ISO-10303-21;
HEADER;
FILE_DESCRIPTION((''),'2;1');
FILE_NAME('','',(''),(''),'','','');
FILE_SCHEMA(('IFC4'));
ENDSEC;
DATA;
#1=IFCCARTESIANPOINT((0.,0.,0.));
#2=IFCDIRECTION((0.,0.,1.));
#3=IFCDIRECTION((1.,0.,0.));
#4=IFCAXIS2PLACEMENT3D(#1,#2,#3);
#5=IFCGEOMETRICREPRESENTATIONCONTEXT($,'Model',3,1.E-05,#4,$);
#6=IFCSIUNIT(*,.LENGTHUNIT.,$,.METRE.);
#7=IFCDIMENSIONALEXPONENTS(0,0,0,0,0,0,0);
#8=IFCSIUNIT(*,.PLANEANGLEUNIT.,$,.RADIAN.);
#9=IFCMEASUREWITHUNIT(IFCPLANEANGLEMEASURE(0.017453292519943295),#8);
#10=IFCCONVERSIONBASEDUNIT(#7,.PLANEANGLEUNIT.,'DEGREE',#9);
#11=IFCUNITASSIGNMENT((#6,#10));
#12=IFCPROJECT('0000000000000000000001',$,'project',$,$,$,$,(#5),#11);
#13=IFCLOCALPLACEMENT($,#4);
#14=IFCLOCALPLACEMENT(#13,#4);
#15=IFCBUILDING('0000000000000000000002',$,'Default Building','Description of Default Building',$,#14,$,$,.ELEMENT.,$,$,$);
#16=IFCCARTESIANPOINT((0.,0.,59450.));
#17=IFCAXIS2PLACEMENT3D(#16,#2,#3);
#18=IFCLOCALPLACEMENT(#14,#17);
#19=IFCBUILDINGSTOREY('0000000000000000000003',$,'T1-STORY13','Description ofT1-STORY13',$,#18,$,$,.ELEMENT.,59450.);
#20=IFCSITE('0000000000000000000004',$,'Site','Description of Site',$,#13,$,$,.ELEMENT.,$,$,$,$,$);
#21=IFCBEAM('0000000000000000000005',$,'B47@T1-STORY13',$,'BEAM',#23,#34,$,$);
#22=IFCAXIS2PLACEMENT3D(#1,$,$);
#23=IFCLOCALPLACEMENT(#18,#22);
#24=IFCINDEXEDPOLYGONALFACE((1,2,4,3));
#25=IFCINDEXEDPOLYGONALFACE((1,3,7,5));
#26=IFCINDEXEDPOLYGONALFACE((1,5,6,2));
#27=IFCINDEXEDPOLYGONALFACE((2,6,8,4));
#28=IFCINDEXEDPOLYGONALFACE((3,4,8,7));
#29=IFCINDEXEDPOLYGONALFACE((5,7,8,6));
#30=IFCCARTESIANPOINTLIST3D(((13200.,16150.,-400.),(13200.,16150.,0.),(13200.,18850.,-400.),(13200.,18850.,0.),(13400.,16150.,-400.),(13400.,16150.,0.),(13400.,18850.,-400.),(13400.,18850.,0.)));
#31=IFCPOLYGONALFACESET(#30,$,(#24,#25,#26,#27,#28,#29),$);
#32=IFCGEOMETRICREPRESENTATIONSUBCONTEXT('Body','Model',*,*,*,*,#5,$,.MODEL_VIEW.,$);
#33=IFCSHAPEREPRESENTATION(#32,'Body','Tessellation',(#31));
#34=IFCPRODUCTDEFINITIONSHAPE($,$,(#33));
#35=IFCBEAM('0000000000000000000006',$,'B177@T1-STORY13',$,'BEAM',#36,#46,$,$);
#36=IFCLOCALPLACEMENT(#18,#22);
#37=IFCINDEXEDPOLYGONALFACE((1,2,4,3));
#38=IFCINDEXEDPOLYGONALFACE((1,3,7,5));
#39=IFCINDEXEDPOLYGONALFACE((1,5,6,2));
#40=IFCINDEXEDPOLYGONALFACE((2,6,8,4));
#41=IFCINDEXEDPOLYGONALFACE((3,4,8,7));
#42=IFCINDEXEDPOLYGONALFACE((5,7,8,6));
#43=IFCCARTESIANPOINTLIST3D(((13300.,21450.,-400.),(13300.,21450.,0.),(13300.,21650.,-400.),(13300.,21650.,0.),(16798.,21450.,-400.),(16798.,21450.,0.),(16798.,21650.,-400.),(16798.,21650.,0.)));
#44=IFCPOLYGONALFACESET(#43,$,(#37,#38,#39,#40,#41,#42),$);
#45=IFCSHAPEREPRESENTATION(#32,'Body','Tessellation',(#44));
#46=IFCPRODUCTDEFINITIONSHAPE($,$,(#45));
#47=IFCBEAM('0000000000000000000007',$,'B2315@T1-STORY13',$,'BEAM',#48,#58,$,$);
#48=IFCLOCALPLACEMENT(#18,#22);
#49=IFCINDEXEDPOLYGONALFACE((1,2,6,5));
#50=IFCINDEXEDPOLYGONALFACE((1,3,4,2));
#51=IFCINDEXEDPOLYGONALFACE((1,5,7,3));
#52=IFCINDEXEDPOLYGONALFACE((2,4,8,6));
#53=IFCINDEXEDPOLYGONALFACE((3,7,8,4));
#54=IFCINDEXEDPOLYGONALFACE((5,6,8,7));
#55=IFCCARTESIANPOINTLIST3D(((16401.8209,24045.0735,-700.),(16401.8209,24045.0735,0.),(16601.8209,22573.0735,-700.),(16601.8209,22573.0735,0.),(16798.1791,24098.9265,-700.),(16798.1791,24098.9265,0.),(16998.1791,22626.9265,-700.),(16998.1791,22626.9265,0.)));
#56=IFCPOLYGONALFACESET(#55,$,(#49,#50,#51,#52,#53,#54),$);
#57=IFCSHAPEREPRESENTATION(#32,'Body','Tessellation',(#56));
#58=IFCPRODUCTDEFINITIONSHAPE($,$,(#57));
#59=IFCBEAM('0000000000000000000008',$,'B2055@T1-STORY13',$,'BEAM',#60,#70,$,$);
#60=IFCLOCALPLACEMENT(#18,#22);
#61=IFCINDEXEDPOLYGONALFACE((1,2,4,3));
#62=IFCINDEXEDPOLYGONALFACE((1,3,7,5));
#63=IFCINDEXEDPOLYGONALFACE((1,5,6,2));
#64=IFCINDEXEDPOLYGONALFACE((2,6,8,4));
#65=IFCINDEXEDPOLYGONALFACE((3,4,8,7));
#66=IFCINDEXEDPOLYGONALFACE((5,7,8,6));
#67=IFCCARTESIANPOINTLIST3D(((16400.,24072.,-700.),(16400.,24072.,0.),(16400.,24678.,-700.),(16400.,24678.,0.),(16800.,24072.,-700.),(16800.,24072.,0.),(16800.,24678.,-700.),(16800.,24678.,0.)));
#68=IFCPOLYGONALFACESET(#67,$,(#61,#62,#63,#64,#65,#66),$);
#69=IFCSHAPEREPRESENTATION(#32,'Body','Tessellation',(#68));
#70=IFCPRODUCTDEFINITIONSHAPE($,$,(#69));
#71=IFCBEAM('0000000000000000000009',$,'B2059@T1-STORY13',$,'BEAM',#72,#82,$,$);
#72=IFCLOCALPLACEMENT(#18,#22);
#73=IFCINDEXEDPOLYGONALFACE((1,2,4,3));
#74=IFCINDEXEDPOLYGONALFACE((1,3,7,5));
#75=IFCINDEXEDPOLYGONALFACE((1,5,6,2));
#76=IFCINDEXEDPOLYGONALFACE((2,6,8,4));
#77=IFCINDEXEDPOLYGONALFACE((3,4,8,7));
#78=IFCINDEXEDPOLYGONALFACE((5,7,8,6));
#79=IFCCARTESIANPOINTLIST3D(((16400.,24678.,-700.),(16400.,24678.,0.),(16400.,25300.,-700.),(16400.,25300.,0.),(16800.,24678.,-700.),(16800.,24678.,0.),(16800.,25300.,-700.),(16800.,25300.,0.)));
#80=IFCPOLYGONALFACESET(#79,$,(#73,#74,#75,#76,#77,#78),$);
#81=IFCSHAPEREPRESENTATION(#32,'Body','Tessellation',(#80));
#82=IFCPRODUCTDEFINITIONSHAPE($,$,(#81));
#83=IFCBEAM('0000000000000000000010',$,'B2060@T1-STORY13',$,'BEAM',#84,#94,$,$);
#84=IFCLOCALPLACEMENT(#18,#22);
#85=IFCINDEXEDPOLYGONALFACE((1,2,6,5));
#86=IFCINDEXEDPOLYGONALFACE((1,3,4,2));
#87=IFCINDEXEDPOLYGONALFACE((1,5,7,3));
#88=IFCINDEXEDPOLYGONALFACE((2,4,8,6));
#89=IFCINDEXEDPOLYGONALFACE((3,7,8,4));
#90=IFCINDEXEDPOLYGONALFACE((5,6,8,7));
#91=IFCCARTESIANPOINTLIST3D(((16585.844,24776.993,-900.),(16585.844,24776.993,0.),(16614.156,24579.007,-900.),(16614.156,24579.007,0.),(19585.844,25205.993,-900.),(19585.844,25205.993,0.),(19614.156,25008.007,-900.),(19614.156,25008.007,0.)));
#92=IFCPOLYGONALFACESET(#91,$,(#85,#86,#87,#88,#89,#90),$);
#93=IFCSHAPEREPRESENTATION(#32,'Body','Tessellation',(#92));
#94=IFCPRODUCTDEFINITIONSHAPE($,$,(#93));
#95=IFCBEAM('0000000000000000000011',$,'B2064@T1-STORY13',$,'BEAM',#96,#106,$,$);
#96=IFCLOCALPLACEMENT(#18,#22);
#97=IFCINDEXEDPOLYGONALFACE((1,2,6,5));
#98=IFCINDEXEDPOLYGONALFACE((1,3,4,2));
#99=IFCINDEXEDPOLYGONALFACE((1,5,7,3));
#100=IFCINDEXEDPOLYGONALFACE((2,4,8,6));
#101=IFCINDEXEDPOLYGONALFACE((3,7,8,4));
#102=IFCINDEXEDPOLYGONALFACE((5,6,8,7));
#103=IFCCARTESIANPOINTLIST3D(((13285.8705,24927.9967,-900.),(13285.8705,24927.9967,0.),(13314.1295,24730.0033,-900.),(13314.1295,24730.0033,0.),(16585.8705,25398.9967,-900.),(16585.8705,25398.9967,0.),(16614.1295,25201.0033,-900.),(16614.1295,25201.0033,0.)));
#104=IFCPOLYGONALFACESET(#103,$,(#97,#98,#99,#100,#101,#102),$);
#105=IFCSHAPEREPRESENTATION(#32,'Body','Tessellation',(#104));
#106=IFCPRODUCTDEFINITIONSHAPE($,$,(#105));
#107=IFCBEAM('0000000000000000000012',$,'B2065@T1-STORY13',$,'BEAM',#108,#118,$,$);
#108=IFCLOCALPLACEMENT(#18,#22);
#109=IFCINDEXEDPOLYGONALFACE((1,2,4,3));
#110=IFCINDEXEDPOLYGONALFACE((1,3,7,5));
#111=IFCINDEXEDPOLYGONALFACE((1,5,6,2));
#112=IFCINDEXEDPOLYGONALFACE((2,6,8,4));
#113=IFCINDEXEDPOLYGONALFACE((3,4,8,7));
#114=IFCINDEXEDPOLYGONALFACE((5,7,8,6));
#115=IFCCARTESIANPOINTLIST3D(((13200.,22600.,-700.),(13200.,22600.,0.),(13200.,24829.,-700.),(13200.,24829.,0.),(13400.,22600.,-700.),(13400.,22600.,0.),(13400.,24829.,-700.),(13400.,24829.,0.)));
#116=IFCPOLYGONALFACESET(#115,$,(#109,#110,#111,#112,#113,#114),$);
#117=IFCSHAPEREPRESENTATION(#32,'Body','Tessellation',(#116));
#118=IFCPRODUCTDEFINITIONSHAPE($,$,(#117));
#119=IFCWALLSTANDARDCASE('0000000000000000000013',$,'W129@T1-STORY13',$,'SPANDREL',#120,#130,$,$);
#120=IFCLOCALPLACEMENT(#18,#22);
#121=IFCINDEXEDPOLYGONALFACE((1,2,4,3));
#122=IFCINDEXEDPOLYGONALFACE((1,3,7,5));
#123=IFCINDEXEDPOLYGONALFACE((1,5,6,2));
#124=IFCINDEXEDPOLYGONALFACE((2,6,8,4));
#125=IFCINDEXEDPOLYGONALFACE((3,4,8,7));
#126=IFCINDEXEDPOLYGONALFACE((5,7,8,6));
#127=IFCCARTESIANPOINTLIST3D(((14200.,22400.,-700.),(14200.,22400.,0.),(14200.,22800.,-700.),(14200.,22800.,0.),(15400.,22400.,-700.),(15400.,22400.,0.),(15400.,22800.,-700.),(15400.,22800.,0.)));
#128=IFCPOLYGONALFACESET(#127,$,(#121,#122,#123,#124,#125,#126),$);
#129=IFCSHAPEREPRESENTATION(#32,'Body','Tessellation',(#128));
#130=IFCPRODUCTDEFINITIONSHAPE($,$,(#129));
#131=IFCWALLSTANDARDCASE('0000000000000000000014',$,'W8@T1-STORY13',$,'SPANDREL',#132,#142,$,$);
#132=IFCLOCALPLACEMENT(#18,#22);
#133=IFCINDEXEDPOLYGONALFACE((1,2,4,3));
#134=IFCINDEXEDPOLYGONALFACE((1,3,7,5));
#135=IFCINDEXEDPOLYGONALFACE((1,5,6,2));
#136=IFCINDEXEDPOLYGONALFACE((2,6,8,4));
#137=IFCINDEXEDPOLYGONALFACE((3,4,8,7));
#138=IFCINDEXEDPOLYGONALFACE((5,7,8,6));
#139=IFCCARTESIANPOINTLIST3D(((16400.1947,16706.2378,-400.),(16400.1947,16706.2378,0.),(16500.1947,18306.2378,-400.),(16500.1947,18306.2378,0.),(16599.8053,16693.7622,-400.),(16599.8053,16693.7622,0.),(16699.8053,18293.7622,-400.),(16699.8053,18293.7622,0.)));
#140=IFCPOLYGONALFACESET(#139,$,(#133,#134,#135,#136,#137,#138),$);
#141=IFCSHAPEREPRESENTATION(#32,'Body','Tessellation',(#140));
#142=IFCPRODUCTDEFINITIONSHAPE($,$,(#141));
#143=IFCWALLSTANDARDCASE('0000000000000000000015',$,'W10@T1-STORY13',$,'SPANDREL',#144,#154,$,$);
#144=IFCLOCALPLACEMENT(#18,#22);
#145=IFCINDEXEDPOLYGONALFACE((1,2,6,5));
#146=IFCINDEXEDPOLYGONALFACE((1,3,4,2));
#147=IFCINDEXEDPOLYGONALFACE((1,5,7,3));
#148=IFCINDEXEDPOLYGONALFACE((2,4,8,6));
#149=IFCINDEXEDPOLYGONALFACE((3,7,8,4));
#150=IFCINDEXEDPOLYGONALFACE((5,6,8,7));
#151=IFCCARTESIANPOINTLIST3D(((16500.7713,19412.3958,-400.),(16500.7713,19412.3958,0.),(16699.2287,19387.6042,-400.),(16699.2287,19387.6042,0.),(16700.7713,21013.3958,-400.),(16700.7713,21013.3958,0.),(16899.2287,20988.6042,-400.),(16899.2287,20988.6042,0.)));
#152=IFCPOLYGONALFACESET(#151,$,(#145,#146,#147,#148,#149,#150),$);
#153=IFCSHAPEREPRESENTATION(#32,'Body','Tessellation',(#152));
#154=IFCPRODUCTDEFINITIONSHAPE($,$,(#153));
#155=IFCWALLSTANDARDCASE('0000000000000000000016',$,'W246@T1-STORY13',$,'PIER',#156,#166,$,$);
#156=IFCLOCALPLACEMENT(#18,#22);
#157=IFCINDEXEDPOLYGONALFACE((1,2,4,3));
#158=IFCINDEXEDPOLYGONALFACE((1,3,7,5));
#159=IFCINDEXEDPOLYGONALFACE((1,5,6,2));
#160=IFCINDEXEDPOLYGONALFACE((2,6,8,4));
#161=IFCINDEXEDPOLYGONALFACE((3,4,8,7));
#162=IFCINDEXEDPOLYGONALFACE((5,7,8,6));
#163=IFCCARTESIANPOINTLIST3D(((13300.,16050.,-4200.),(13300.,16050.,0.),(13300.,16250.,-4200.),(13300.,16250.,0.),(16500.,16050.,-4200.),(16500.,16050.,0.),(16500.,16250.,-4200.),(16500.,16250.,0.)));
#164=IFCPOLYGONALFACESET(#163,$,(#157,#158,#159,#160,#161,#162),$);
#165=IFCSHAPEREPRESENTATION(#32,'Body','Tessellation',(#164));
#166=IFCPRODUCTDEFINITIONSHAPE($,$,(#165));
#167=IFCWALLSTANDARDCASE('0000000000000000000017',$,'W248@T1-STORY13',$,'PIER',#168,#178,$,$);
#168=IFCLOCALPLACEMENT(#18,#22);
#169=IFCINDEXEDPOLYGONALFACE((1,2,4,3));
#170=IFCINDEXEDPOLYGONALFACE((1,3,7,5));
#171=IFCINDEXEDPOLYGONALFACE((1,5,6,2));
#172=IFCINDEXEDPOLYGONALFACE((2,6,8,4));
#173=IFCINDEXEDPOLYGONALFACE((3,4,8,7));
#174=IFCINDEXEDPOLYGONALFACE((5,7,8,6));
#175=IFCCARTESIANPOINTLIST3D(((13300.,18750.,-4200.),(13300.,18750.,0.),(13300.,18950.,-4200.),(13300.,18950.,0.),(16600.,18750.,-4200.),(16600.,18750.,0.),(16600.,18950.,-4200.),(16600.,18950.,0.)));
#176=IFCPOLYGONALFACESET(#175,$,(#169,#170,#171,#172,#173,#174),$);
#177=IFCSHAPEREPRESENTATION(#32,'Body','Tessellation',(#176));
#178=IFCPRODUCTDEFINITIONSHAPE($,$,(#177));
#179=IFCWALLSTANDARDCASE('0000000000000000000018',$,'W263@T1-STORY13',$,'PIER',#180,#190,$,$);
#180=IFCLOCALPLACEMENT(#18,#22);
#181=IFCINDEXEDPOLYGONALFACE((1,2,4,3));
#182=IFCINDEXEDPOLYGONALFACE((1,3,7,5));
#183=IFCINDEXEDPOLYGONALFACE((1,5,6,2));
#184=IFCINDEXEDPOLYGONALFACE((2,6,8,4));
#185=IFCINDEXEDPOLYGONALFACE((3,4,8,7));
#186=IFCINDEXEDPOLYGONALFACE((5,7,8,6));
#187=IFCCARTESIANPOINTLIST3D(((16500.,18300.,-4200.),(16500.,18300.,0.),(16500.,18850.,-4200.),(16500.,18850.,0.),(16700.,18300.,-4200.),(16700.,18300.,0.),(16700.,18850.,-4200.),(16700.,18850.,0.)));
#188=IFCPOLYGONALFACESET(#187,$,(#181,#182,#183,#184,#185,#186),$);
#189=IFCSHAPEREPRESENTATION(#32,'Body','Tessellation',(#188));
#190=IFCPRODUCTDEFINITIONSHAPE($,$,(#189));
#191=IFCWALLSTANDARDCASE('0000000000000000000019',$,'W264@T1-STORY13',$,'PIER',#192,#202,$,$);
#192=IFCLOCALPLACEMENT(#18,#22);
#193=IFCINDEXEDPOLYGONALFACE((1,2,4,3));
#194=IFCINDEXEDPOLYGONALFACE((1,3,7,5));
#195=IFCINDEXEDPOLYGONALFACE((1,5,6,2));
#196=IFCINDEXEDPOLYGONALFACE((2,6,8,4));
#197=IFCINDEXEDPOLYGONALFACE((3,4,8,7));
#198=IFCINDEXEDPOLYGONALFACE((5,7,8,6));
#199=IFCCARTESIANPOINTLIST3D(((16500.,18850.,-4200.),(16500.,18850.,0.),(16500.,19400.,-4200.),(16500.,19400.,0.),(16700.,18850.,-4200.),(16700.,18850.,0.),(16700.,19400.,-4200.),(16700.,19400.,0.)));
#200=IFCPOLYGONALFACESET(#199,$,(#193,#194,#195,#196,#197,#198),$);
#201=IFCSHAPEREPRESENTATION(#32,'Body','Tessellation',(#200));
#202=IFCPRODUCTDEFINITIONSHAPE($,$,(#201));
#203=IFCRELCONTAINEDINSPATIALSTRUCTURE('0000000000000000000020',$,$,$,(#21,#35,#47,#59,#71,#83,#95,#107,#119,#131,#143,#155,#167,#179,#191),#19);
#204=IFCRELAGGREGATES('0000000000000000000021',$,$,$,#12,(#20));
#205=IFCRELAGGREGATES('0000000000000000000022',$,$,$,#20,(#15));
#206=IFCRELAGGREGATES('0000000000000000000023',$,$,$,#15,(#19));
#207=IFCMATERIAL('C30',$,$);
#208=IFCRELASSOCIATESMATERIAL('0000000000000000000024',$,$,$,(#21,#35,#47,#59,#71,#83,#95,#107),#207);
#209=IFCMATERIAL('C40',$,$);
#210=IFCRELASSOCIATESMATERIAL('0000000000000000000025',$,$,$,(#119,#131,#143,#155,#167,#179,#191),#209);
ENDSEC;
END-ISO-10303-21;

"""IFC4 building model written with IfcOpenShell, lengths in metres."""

from ifc_helpers import new_model, entity, si_unit, converted_unit, frame, origin_with_axes, place, context, subcontext, project, spatial, indexed_curve, rectangle, outline, extrude, material, element, save


model = new_model("IFC4")

# Units and contexts
model_context = context("Model", 3, precision=1e-05, world=origin_with_axes())
body_context = subcontext(model_context, "Body", "Model", "MODEL_VIEW")
ifc_project = project(units=[si_unit("LENGTHUNIT", "METRE"), converted_unit("PLANEANGLEUNIT", "DEGREE", entity("IfcPlaneAngleMeasure", 0.017453292519943295), si_unit("PLANEANGLEUNIT", "RADIAN"), dimensions=[0, 0, 0, 0, 0, 0, 0])], contexts=[model_context])

# Site, building, storey
site_placement = place(None, origin_with_axes())
site = spatial("IfcSite", under=ifc_project, at=site_placement, Name="Site", Description="Description of Site", CompositionType="ELEMENT")
building_placement = place(site_placement, origin_with_axes())
building = spatial("IfcBuilding", under=site, at=building_placement, Name="Default Building", Description="Description of Default Building", CompositionType="ELEMENT")
storey_placement = place(building_placement, frame((0.0, 0.0, 59450.0), z_axis=(0.0, 0.0, 1.0), x_axis=(1.0, 0.0, 0.0)))
storey = spatial("IfcBuildingStorey", under=building, at=storey_placement, Name="T1-STORY13", Description="Description ofT1-STORY13", CompositionType="ELEMENT", Elevation=59450.0)

# Beams
ifc_material_1 = material(Name="C30")
beam_1_placement = place(storey_placement, frame((13300.0, 16150.0, -200.0), z_axis=(0.0, 1.0, 0.0), x_axis=(-1.0, 0.0, 0.0)))
element("IfcBeam", 1, at=beam_1_placement, inside=storey, material=ifc_material_1, Name="B47@T1-STORY13", ObjectType="BEAM", context=body_context, shape_type="SweptSolid", body=[
    extrude(rectangle(XDim=200.0, YDim=400.0), origin_with_axes(), (0.0, 0.0, 1.0), 2700.0),
])
beam_2_placement = place(storey_placement, frame((13300.0, 21550.0, -200.0), z_axis=(1.0, 0.0, 0.0), x_axis=(0.0, 1.0, 0.0)))
element("IfcBeam", 2, at=beam_2_placement, inside=storey, material=ifc_material_1, Name="B177@T1-STORY13", ObjectType="BEAM", context=body_context, shape_type="SweptSolid", body=[
    extrude(rectangle(XDim=200.0, YDim=400.0), origin_with_axes(), (0.0, 0.0, 1.0), 3498.0),
])
beam_3_placement = place(storey_placement, frame((16600.0, 24072.0, -350.0), z_axis=(0.134633, -0.990896, 0.0), x_axis=(0.990896, 0.134633, 0.0)))
element("IfcBeam", 3, at=beam_3_placement, inside=storey, material=ifc_material_1, Name="B2315@T1-STORY13", ObjectType="BEAM", context=body_context, shape_type="SweptSolid", body=[
    extrude(rectangle(XDim=400.0, YDim=700.0), origin_with_axes(), (0.0, 0.0, 1.0), 1485.5248),
])
beam_4_placement = place(storey_placement, frame((16600.0, 24072.0, -350.0), z_axis=(0.0, 1.0, 0.0), x_axis=(-1.0, 0.0, 0.0)))
element("IfcBeam", 4, at=beam_4_placement, inside=storey, material=ifc_material_1, Name="B2055@T1-STORY13", ObjectType="BEAM", context=body_context, shape_type="SweptSolid", body=[
    extrude(rectangle(XDim=400.0, YDim=700.0), origin_with_axes(), (0.0, 0.0, 1.0), 606.0),
])
beam_5_placement = place(storey_placement, frame((16600.0, 24678.0, -350.0), z_axis=(0.0, 1.0, 0.0), x_axis=(-1.0, 0.0, 0.0)))
element("IfcBeam", 5, at=beam_5_placement, inside=storey, material=ifc_material_1, Name="B2059@T1-STORY13", ObjectType="BEAM", context=body_context, shape_type="SweptSolid", body=[
    extrude(rectangle(XDim=400.0, YDim=700.0), origin_with_axes(), (0.0, 0.0, 1.0), 622.0),
])
beam_6_placement = place(storey_placement, frame((16600.0, 24678.0, -450.0), z_axis=(0.98993, 0.14156, 0.0), x_axis=(-0.14156, 0.98993, 0.0)))
element("IfcBeam", 6, at=beam_6_placement, inside=storey, material=ifc_material_1, Name="B2060@T1-STORY13", ObjectType="BEAM", context=body_context, shape_type="SweptSolid", body=[
    extrude(rectangle(XDim=200.0, YDim=900.0), origin_with_axes(), (0.0, 0.0, 1.0), 3030.5183),
])
beam_7_placement = place(storey_placement, frame((13300.0, 24829.0, -450.0), z_axis=(0.989967, 0.141295, 0.0), x_axis=(-0.141295, 0.989967, 0.0)))
element("IfcBeam", 7, at=beam_7_placement, inside=storey, material=ifc_material_1, Name="B2064@T1-STORY13", ObjectType="BEAM", context=body_context, shape_type="SweptSolid", body=[
    extrude(rectangle(XDim=200.0, YDim=900.0), origin_with_axes(), (0.0, 0.0, 1.0), 3333.4428),
])
beam_8_placement = place(storey_placement, frame((13300.0, 22600.0, -350.0), z_axis=(0.0, 1.0, 0.0), x_axis=(-1.0, 0.0, 0.0)))
element("IfcBeam", 8, at=beam_8_placement, inside=storey, material=ifc_material_1, Name="B2065@T1-STORY13", ObjectType="BEAM", context=body_context, shape_type="SweptSolid", body=[
    extrude(rectangle(XDim=200.0, YDim=700.0), origin_with_axes(), (0.0, 0.0, 1.0), 2229.0),
])

# Walls
ifc_material_2 = material(Name="C40")
wall_1_placement = place(storey_placement, frame((14200.0, 22600.0, -700.0), z_axis=(0.0, 0.0, 1.0), x_axis=(1.0, 0.0, 0.0)))
element("IfcWallStandardCase", 9, at=wall_1_placement, inside=storey, material=ifc_material_2, Name="W129@T1-STORY13", ObjectType="SPANDREL", context=body_context, shape_type="SweptSolid", body=[
    extrude(outline(indexed_curve([(0.0, -200.0), (0.0, 200.0), (1200.0, 200.0), (1200.0, -200.0), (0.0, -200.0)], self_intersect=False)), origin_with_axes(), (0.0, 0.0, 1.0), 700.0),
])
wall_2_placement = place(storey_placement, frame((16500.0, 16700.0, -400.0), z_axis=(0.0, 0.0, 1.0), x_axis=(0.062378, 0.998053, 0.0)))
element("IfcWallStandardCase", 10, at=wall_2_placement, inside=storey, material=ifc_material_2, Name="W8@T1-STORY13", ObjectType="SPANDREL", context=body_context, shape_type="SweptSolid", body=[
    extrude(outline(indexed_curve([(0.0, -100.0), (0.0, 100.0), (1603.122, 100.0), (1603.122, -100.0), (0.0, -100.0)], self_intersect=False)), origin_with_axes(), (0.0, 0.0, 1.0), 400.0),
])
wall_3_placement = place(storey_placement, frame((16600.0, 19400.0, -400.0), z_axis=(0.0, 0.0, 1.0), x_axis=(0.123958, 0.992287, 0.0)))
element("IfcWallStandardCase", 11, at=wall_3_placement, inside=storey, material=ifc_material_2, Name="W10@T1-STORY13", ObjectType="SPANDREL", context=body_context, shape_type="SweptSolid", body=[
    extrude(outline(indexed_curve([(0.0, -100.0), (0.0, 100.0), (1613.4438, 100.0), (1613.4438, -100.0), (0.0, -100.0)], self_intersect=False)), origin_with_axes(), (0.0, 0.0, 1.0), 400.0),
])
wall_4_placement = place(storey_placement, frame((13300.0, 16150.0, -4200.0), z_axis=(0.0, 0.0, 1.0), x_axis=(1.0, 0.0, 0.0)))
element("IfcWallStandardCase", 12, at=wall_4_placement, inside=storey, material=ifc_material_2, Name="W246@T1-STORY13", ObjectType="PIER", context=body_context, shape_type="SweptSolid", body=[
    extrude(outline(indexed_curve([(0.0, -100.0), (0.0, 100.0), (3200.0, 100.0), (3200.0, -100.0), (0.0, -100.0)], self_intersect=False)), origin_with_axes(), (0.0, 0.0, 1.0), 4200.0),
])
wall_5_placement = place(storey_placement, frame((13300.0, 18850.0, -4200.0), z_axis=(0.0, 0.0, 1.0), x_axis=(1.0, 0.0, 0.0)))
element("IfcWallStandardCase", 13, at=wall_5_placement, inside=storey, material=ifc_material_2, Name="W248@T1-STORY13", ObjectType="PIER", context=body_context, shape_type="SweptSolid", body=[
    extrude(outline(indexed_curve([(0.0, -100.0), (0.0, 100.0), (3300.0, 100.0), (3300.0, -100.0), (0.0, -100.0)], self_intersect=False)), origin_with_axes(), (0.0, 0.0, 1.0), 4200.0),
])
for number, where, z_axis, x_axis, name in (
    (14, (16600.0, 18300.0, -4200.0), (0.0, 0.0, 1.0), (0.0, 1.0, 0.0), "W263@T1-STORY13"),
    (15, (16600.0, 18850.0, -4200.0), (0.0, 0.0, 1.0), (0.0, 1.0, 0.0), "W264@T1-STORY13"),
):
    element("IfcWallStandardCase", number, at=place(storey_placement, frame(where, z_axis=z_axis, x_axis=x_axis)), inside=storey, material=ifc_material_2, Name=name, ObjectType="PIER", context=body_context, shape_type="SweptSolid", body=[
        extrude(outline(indexed_curve([(0.0, -100.0), (0.0, 100.0), (550.0, 100.0), (550.0, -100.0), (0.0, -100.0)], self_intersect=False)), origin_with_axes(), (0.0, 0.0, 1.0), 4200.0),
    ])

save(model, "model.ifc")
